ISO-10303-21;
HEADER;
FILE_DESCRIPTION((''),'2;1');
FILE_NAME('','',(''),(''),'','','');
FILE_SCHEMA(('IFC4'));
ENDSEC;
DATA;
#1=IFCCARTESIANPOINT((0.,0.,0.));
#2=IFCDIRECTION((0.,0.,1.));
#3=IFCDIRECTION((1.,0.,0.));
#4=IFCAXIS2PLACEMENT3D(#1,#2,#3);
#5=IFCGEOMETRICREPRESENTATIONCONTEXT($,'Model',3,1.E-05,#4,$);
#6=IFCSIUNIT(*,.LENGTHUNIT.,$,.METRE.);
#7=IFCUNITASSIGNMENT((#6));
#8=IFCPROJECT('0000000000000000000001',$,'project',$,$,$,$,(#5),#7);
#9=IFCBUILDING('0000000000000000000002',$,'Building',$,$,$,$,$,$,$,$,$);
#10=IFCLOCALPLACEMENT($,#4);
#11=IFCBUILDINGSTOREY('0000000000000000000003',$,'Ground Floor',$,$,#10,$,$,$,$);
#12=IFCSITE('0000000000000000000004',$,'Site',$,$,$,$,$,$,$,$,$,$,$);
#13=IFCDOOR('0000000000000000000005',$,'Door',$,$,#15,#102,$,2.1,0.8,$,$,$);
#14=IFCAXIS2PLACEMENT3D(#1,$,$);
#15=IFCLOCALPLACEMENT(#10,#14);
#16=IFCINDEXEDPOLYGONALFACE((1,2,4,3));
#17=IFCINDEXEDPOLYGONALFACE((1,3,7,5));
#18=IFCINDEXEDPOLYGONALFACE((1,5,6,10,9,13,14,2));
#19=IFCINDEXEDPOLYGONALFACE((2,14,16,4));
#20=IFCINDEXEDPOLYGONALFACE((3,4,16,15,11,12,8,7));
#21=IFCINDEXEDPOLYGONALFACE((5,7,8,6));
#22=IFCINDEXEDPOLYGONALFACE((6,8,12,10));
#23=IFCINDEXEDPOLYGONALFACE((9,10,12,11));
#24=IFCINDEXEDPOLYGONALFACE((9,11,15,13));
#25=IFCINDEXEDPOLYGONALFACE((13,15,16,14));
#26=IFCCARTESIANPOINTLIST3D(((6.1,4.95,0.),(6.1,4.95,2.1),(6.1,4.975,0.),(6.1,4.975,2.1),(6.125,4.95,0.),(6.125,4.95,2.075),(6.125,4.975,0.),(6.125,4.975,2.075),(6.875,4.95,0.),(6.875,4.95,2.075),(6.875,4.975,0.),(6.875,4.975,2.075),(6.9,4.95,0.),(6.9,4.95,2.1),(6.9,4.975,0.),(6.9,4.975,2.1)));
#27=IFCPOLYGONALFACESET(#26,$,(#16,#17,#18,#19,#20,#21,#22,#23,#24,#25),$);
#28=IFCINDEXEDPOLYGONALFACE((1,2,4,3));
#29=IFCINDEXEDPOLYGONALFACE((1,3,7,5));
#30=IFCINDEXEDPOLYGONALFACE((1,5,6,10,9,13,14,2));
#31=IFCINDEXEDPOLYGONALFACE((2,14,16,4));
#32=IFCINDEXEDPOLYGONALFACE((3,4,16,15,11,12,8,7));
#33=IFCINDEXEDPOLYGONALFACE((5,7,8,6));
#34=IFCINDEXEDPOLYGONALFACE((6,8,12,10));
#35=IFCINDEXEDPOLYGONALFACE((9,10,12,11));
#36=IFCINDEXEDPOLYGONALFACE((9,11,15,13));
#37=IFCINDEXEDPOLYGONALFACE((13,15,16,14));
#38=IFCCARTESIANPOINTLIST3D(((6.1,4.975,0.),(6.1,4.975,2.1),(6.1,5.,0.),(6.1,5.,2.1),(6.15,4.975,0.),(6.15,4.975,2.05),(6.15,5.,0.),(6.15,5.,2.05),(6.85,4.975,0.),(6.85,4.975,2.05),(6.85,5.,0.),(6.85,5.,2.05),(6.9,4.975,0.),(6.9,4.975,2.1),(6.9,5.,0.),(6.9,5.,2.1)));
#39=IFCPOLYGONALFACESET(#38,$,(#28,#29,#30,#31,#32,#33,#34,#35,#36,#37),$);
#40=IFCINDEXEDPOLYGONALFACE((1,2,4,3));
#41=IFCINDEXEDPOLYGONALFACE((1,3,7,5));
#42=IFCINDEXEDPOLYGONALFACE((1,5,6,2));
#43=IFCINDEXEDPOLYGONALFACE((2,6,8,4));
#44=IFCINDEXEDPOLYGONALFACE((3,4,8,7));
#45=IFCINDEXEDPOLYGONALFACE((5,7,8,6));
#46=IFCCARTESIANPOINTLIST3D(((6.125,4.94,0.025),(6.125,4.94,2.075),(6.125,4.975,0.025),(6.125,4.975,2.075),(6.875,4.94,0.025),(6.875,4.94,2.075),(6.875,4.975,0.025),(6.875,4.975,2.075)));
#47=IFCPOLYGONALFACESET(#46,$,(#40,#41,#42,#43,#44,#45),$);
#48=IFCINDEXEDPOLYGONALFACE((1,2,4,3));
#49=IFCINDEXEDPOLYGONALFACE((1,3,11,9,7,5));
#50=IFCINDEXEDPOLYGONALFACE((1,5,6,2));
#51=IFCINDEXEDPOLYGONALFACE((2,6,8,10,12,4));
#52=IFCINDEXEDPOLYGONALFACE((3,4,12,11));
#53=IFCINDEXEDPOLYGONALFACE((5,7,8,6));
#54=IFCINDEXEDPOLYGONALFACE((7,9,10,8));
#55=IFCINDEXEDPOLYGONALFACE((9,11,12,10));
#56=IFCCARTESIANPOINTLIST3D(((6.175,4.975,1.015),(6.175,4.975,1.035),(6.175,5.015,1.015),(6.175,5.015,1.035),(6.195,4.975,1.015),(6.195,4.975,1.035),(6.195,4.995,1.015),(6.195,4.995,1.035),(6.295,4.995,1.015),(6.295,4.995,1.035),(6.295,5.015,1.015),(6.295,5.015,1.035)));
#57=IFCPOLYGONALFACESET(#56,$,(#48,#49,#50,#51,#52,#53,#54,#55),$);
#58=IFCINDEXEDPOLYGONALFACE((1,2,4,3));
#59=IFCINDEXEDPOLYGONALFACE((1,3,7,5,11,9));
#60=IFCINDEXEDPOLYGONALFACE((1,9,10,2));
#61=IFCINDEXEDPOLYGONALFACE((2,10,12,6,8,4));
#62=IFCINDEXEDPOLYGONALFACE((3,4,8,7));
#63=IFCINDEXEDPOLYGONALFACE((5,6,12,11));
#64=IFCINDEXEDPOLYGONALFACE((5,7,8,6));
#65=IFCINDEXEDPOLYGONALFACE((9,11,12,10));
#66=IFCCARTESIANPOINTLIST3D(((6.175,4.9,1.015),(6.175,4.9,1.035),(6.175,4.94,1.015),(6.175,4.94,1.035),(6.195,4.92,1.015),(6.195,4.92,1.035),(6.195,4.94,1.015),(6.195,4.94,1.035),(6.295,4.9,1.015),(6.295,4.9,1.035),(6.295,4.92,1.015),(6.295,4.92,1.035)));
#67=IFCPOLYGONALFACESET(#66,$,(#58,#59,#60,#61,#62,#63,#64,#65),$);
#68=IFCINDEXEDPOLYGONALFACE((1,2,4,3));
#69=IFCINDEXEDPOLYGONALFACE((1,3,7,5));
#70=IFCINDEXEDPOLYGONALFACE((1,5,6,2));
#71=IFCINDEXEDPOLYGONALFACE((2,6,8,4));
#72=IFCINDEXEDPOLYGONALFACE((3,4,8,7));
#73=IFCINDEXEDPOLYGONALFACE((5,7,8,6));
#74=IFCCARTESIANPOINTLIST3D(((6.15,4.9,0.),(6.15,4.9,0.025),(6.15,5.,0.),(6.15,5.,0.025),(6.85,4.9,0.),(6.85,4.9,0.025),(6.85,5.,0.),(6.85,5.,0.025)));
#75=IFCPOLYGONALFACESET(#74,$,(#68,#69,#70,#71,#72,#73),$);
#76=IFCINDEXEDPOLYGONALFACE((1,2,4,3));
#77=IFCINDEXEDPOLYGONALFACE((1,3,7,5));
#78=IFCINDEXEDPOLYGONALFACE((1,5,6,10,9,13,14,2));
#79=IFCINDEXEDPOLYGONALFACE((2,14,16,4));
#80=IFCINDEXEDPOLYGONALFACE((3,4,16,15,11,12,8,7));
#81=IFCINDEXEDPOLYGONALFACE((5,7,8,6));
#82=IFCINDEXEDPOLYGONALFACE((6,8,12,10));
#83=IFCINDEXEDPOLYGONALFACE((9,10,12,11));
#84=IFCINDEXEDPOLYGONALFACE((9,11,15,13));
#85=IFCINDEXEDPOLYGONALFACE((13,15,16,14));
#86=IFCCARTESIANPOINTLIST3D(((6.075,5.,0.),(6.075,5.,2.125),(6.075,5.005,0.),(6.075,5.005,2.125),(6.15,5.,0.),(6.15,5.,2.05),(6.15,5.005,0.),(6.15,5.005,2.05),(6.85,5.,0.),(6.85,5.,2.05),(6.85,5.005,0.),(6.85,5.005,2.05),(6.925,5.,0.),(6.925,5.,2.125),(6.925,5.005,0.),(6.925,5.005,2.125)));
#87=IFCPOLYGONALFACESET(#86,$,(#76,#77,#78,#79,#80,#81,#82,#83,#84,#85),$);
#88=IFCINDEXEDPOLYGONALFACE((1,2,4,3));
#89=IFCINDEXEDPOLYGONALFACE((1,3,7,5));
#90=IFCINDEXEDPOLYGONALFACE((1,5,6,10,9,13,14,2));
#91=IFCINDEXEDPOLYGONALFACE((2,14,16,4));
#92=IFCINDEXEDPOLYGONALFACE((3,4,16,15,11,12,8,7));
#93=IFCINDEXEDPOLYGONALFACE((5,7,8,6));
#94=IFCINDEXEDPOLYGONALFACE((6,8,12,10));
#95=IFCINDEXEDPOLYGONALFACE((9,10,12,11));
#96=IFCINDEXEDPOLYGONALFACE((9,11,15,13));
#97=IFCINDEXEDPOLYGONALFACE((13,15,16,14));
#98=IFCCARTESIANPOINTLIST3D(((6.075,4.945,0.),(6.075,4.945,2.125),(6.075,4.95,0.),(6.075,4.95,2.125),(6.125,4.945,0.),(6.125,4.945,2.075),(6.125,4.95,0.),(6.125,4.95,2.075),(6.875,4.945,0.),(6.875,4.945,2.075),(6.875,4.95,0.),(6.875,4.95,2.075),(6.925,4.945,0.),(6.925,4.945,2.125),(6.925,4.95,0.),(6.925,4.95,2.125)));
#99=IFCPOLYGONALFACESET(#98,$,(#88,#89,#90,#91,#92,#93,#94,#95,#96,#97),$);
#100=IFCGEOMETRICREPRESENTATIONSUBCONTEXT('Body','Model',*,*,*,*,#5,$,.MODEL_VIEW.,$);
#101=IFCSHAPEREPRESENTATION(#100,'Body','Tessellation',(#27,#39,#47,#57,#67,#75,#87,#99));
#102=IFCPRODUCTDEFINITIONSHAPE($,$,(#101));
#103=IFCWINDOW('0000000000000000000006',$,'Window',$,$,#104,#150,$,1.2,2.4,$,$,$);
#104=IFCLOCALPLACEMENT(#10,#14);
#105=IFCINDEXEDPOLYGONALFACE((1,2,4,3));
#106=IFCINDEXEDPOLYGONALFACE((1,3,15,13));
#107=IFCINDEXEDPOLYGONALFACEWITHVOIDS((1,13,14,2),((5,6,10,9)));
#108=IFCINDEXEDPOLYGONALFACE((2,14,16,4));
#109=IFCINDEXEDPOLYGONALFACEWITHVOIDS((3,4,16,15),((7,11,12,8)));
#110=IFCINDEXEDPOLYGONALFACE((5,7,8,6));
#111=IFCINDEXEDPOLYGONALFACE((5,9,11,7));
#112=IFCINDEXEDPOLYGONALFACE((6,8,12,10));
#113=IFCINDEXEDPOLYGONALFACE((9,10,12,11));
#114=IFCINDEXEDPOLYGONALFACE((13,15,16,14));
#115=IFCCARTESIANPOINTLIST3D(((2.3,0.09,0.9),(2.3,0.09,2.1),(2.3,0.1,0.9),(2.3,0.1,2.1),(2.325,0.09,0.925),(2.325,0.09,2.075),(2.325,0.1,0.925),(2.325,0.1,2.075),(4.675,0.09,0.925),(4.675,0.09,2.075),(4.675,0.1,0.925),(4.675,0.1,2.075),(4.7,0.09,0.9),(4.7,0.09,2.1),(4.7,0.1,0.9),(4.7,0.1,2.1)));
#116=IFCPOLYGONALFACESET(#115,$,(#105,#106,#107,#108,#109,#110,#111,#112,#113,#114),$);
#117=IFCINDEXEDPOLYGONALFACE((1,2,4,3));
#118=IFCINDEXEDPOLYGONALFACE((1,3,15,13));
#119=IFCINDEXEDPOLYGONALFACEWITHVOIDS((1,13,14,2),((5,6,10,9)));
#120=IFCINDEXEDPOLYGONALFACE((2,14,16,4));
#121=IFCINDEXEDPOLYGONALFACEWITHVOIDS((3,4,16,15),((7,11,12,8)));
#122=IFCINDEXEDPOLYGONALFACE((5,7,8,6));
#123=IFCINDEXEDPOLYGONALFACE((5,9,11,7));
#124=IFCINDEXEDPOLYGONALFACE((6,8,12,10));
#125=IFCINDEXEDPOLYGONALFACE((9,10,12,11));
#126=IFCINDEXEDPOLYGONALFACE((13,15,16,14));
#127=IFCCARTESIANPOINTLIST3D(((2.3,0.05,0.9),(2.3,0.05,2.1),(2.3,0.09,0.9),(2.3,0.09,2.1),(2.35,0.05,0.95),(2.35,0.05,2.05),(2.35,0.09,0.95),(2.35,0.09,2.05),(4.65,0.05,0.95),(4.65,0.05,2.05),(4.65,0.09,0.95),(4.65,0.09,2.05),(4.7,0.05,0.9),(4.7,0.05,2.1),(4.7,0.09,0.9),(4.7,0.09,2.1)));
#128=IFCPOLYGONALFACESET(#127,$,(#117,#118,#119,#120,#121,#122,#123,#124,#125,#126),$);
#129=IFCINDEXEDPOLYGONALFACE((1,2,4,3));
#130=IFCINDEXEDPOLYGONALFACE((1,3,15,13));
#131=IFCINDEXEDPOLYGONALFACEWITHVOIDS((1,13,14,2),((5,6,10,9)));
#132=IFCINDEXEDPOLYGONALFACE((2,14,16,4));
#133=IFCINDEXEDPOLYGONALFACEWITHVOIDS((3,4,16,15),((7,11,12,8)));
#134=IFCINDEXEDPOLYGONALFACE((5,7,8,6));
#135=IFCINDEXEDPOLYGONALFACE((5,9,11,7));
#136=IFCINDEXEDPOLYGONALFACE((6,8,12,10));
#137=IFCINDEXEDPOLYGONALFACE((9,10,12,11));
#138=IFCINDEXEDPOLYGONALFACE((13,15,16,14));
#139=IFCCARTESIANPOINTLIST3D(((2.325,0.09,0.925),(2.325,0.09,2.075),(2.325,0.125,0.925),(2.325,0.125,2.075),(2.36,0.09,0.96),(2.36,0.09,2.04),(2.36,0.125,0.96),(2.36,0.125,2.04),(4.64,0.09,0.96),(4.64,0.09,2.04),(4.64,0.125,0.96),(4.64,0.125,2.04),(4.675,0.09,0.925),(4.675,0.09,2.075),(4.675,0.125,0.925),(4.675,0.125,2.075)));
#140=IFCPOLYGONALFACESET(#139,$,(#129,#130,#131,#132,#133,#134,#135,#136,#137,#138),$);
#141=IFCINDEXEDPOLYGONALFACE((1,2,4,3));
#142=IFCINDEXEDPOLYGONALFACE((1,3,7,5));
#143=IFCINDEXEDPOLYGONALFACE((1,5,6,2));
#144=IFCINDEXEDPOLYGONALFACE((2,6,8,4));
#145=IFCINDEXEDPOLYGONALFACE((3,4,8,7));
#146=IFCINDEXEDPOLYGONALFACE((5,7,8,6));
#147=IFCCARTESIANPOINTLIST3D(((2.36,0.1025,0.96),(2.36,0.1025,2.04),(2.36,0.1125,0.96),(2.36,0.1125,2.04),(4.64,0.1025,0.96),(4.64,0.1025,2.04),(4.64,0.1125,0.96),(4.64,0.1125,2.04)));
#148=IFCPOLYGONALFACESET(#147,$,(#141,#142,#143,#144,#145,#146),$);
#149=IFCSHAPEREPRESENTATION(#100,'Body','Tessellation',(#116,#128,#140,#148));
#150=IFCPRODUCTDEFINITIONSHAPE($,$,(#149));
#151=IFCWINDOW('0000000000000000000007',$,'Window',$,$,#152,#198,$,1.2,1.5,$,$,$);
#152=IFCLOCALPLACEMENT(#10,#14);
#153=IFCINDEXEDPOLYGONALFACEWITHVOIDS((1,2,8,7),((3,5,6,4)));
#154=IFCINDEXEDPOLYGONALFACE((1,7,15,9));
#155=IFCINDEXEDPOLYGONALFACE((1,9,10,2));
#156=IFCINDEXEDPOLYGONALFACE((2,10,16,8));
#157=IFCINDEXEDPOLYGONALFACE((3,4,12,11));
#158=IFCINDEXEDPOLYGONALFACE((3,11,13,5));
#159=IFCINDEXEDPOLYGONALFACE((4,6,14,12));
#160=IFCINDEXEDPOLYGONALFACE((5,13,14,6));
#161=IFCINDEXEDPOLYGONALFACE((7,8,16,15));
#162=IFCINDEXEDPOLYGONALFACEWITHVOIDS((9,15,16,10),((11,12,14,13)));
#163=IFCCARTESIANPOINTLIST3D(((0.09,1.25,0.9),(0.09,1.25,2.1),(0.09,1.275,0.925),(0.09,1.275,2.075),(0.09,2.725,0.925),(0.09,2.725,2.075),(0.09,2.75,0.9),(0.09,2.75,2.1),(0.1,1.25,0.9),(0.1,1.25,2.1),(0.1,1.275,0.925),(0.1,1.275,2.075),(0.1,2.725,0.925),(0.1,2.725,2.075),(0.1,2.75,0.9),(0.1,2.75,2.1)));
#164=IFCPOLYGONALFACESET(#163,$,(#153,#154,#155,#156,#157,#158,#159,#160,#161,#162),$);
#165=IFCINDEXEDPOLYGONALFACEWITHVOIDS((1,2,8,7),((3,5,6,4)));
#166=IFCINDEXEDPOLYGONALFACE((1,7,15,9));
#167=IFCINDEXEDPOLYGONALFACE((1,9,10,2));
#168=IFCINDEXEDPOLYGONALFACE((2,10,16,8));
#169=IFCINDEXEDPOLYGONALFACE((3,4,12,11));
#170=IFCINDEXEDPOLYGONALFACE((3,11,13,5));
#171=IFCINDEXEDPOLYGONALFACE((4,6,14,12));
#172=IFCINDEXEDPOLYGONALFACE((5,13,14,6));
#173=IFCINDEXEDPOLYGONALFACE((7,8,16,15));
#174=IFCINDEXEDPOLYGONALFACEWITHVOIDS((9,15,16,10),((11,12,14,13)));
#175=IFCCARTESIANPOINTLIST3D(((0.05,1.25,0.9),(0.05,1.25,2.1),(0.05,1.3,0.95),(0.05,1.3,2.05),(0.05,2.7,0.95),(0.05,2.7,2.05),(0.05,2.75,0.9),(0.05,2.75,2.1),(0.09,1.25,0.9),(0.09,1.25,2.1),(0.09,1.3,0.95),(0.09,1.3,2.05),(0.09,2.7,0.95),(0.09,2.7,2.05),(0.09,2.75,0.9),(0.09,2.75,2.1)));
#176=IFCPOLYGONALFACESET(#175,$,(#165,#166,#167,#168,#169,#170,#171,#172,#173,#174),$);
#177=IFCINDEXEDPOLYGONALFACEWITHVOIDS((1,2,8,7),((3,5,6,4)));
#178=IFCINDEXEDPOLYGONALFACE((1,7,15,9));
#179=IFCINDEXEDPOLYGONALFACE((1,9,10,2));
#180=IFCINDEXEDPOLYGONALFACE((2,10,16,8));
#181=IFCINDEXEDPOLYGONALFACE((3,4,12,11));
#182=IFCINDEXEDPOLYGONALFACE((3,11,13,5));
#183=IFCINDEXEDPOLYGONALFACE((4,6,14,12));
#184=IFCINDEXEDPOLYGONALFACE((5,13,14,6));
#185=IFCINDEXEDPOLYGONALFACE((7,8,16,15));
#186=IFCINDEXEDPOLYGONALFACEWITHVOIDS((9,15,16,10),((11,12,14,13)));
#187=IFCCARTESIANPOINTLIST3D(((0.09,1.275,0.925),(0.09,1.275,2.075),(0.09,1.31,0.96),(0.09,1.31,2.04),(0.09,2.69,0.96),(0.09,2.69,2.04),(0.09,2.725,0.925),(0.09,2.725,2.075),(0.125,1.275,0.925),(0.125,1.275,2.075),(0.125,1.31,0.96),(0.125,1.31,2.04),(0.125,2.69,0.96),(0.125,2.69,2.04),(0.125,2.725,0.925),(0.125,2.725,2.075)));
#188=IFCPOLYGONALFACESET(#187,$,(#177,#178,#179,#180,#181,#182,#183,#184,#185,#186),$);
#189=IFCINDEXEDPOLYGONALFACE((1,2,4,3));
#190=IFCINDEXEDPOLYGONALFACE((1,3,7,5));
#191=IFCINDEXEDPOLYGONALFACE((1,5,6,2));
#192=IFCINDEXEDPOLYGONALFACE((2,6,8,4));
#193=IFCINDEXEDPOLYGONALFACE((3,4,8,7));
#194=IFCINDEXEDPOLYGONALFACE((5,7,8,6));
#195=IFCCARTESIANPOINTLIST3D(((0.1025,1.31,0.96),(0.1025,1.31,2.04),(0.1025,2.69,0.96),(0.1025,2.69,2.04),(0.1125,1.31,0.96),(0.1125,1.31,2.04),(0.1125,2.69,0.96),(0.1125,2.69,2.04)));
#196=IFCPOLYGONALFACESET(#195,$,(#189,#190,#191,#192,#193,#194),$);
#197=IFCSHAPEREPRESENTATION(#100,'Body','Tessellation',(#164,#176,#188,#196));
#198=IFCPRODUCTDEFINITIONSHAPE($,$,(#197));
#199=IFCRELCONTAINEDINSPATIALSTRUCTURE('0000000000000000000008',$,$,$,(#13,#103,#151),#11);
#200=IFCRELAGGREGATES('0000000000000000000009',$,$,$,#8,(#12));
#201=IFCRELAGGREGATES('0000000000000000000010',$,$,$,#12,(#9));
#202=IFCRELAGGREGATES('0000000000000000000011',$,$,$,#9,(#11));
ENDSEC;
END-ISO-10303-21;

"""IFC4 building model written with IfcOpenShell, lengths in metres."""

from ifc_helpers import new_model, si_unit, frame, origin_with_axes, place, context, subcontext, project, spatial, line, indexed_curve, outline, extrude, element, save


model = new_model("IFC4")

# Units and contexts
model_context = context("Model", 3, precision=1e-05, world=origin_with_axes())
body_context = subcontext(model_context, "Body", "Model", "MODEL_VIEW")
ifc_project = project(units=[si_unit("LENGTHUNIT", "METRE")], contexts=[model_context])

# Site, building, storey
site = spatial("IfcSite", under=ifc_project, Name="Site")
building = spatial("IfcBuilding", under=site, Name="Building")
storey_placement = place(None, origin_with_axes())
storey = spatial("IfcBuildingStorey", under=building, at=storey_placement, Name="Ground Floor")

# Door
door_1_placement = place(storey_placement, frame((6.9, 5.0, 0.0), z_axis=(0.0, 0.0, 1.0), x_axis=(-1.0, 0.0, 0.0)))
element("IfcDoor", 1, at=door_1_placement, inside=storey, Name="Door", OverallHeight=2.1, OverallWidth=0.8, context=body_context, shape_type="SweptSolid", body=[
    extrude(outline(indexed_curve([(0.0, 0.0), (0.0, 2.1), (0.8, 2.1), (0.8, 0.0), (0.775, 0.0), (0.775, 2.075), (0.025, 2.075), (0.025, 0.0)], segments=[line(1, 2, 3, 4, 5, 6, 7, 8, 1)])), frame((0.0, 0.025, 0.0), z_axis=(0.0, -1.0, 0.0), x_axis=(1.0, 0.0, 0.0)), (0.0, 0.0, -1.0), 0.025),
    extrude(outline(indexed_curve([(0.0, 0.0), (0.0, 2.1), (0.8, 2.1), (0.8, 0.0), (0.75, 0.0), (0.75, 2.05), (0.05, 2.05), (0.05, 0.0)], segments=[line(1, 2, 3, 4, 5, 6, 7, 8, 1)])), frame((0.0, 0.0, 0.0), z_axis=(0.0, -1.0, 0.0), x_axis=(1.0, 0.0, 0.0)), (0.0, 0.0, -1.0), 0.025),
    extrude(outline(indexed_curve([(0.0, 0.0), (0.75, 0.0), (0.75, 0.035), (0.0, 0.035)], segments=[line(1, 2, 3, 4, 1)])), frame((0.025, 0.025, 0.025), z_axis=(0.0, 0.0, 1.0), x_axis=(1.0, 0.0, 0.0)), (0.0, 0.0, 1.0), 2.05),
    extrude(outline(indexed_curve([(0.0, 0.0), (0.0, -0.04), (-0.12, -0.04), (-0.12, -0.02), (-0.02, -0.02), (-0.02, 0.0)], segments=[line(1, 2, 3, 4, 5, 6, 1)])), frame((0.725, 0.025, 1.015), z_axis=(0.0, 0.0, 1.0), x_axis=(1.0, 0.0, 0.0)), (0.0, 0.0, 1.0), 0.02),
    extrude(outline(indexed_curve([(0.0, 0.0), (0.0, 0.04), (-0.12, 0.04), (-0.12, 0.02), (-0.02, 0.02), (-0.02, 0.0)], segments=[line(1, 2, 3, 4, 5, 6, 1)])), frame((0.725, 0.06, 1.015), z_axis=(0.0, 0.0, 1.0), x_axis=(1.0, 0.0, 0.0)), (0.0, 0.0, 1.0), 0.02),
    extrude(outline(indexed_curve([(0.0, 0.0), (0.7, 0.0), (0.7, 0.1), (0.0, 0.1)], segments=[line(1, 2, 3, 4, 1)])), frame((0.05, 0.0, 0.0), z_axis=(0.0, 0.0, 1.0), x_axis=(1.0, 0.0, 0.0)), (0.0, 0.0, 1.0), 0.025),
    extrude(outline(indexed_curve([(0.0, 0.0), (0.0, 2.125), (0.85, 2.125), (0.85, 0.0), (0.775, 0.0), (0.775, 2.05), (0.075, 2.05), (0.075, 0.0)], segments=[line(1, 2, 3, 4, 5, 6, 7, 8, 1)])), frame((-0.025, -0.005, 0.0), z_axis=(0.0, -1.0, 0.0), x_axis=(1.0, 0.0, 0.0)), (0.0, 0.0, -1.0), 0.005),
    extrude(outline(indexed_curve([(0.0, 0.0), (0.0, 2.125), (0.85, 2.125), (0.85, 0.0), (0.8, 0.0), (0.8, 2.075), (0.05, 2.075), (0.05, 0.0)], segments=[line(1, 2, 3, 4, 5, 6, 7, 8, 1)])), frame((-0.025, 0.05, 0.0), z_axis=(0.0, -1.0, 0.0), x_axis=(1.0, 0.0, 0.0)), (0.0, 0.0, -1.0), 0.005),
])

# Windows
window_placement = place(storey_placement, frame((2.3, 0.0, 0.9), z_axis=(0.0, 0.0, 1.0), x_axis=(1.0, 0.0, 0.0)))
element("IfcWindow", 2, at=window_placement, inside=storey, Name="Window", OverallHeight=1.2, OverallWidth=2.4, context=body_context, shape_type="SweptSolid", body=[
    extrude(outline(indexed_curve([(0.0, 0.0), (2.4, 0.0), (2.4, 1.2), (0.0, 1.2)], segments=[line(1, 2, 3, 4, 1)]), holes=[indexed_curve([(0.025, 0.025), (2.375, 0.025), (2.375, 1.175), (0.025, 1.175)], segments=[line(1, 2, 3, 4, 1)])]), frame((0.0, 0.09, 0.0), z_axis=(0.0, -1.0, 0.0), x_axis=(1.0, 0.0, 0.0)), (0.0, 0.0, -1.0), 0.01),
    extrude(outline(indexed_curve([(0.0, 0.0), (2.4, 0.0), (2.4, 1.2), (0.0, 1.2)], segments=[line(1, 2, 3, 4, 1)]), holes=[indexed_curve([(0.05, 0.05), (2.35, 0.05), (2.35, 1.15), (0.05, 1.15)], segments=[line(1, 2, 3, 4, 1)])]), frame((0.0, 0.05, 0.0), z_axis=(0.0, -1.0, 0.0), x_axis=(1.0, 0.0, 0.0)), (0.0, 0.0, -1.0), 0.04),
    extrude(outline(indexed_curve([(0.0, 0.0), (2.35, 0.0), (2.35, 1.15), (0.0, 1.15)], segments=[line(1, 2, 3, 4, 1)]), holes=[indexed_curve([(0.035, 0.035), (2.315, 0.035), (2.315, 1.115), (0.035, 1.115)], segments=[line(1, 2, 3, 4, 1)])]), frame((0.025, 0.09, 0.025), z_axis=(0.0, -1.0, 0.0), x_axis=(1.0, 0.0, 0.0)), (0.0, 0.0, -1.0), 0.035),
    extrude(outline(indexed_curve([(0.035, 0.035), (2.315, 0.035), (2.315, 1.115), (0.035, 1.115)], segments=[line(1, 2, 3, 4, 1)])), frame((0.025, 0.1025, 0.025), z_axis=(0.0, -1.0, 0.0), x_axis=(1.0, 0.0, 0.0)), (0.0, 0.0, -1.0), 0.01),
])
for number, where, z_axis, x_axis, name in (
    (3, (0.0, 2.75, 0.9), (0.0, 0.0, 1.0), (0.0, -1.0, 0.0), "Window"),
):
    element("IfcWindow", number, at=place(storey_placement, frame(where, z_axis=z_axis, x_axis=x_axis)), inside=storey, Name=name, OverallHeight=1.2, OverallWidth=1.5, context=body_context, shape_type="SweptSolid", body=[
        extrude(outline(indexed_curve([(0.0, 0.0), (1.5, 0.0), (1.5, 1.2), (0.0, 1.2)], segments=[line(1, 2, 3, 4, 1)]), holes=[indexed_curve([(0.025, 0.025), (1.475, 0.025), (1.475, 1.175), (0.025, 1.175)], segments=[line(1, 2, 3, 4, 1)])]), frame((0.0, 0.09, 0.0), z_axis=(0.0, -1.0, 0.0), x_axis=(1.0, 0.0, 0.0)), (0.0, 0.0, -1.0), 0.01),
        extrude(outline(indexed_curve([(0.0, 0.0), (1.5, 0.0), (1.5, 1.2), (0.0, 1.2)], segments=[line(1, 2, 3, 4, 1)]), holes=[indexed_curve([(0.05, 0.05), (1.45, 0.05), (1.45, 1.15), (0.05, 1.15)], segments=[line(1, 2, 3, 4, 1)])]), frame((0.0, 0.05, 0.0), z_axis=(0.0, -1.0, 0.0), x_axis=(1.0, 0.0, 0.0)), (0.0, 0.0, -1.0), 0.04),
        extrude(outline(indexed_curve([(0.0, 0.0), (1.45, 0.0), (1.45, 1.15), (0.0, 1.15)], segments=[line(1, 2, 3, 4, 1)]), holes=[indexed_curve([(0.035, 0.035), (1.415, 0.035), (1.415, 1.115), (0.035, 1.115)], segments=[line(1, 2, 3, 4, 1)])]), frame((0.025, 0.09, 0.025), z_axis=(0.0, -1.0, 0.0), x_axis=(1.0, 0.0, 0.0)), (0.0, 0.0, -1.0), 0.035),
        extrude(outline(indexed_curve([(0.035, 0.035), (1.415, 0.035), (1.415, 1.115), (0.035, 1.115)], segments=[line(1, 2, 3, 4, 1)])), frame((0.025, 0.1025, 0.025), z_axis=(0.0, -1.0, 0.0), x_axis=(1.0, 0.0, 0.0)), (0.0, 0.0, -1.0), 0.01),
    ])

save(model, "model.ifc")
